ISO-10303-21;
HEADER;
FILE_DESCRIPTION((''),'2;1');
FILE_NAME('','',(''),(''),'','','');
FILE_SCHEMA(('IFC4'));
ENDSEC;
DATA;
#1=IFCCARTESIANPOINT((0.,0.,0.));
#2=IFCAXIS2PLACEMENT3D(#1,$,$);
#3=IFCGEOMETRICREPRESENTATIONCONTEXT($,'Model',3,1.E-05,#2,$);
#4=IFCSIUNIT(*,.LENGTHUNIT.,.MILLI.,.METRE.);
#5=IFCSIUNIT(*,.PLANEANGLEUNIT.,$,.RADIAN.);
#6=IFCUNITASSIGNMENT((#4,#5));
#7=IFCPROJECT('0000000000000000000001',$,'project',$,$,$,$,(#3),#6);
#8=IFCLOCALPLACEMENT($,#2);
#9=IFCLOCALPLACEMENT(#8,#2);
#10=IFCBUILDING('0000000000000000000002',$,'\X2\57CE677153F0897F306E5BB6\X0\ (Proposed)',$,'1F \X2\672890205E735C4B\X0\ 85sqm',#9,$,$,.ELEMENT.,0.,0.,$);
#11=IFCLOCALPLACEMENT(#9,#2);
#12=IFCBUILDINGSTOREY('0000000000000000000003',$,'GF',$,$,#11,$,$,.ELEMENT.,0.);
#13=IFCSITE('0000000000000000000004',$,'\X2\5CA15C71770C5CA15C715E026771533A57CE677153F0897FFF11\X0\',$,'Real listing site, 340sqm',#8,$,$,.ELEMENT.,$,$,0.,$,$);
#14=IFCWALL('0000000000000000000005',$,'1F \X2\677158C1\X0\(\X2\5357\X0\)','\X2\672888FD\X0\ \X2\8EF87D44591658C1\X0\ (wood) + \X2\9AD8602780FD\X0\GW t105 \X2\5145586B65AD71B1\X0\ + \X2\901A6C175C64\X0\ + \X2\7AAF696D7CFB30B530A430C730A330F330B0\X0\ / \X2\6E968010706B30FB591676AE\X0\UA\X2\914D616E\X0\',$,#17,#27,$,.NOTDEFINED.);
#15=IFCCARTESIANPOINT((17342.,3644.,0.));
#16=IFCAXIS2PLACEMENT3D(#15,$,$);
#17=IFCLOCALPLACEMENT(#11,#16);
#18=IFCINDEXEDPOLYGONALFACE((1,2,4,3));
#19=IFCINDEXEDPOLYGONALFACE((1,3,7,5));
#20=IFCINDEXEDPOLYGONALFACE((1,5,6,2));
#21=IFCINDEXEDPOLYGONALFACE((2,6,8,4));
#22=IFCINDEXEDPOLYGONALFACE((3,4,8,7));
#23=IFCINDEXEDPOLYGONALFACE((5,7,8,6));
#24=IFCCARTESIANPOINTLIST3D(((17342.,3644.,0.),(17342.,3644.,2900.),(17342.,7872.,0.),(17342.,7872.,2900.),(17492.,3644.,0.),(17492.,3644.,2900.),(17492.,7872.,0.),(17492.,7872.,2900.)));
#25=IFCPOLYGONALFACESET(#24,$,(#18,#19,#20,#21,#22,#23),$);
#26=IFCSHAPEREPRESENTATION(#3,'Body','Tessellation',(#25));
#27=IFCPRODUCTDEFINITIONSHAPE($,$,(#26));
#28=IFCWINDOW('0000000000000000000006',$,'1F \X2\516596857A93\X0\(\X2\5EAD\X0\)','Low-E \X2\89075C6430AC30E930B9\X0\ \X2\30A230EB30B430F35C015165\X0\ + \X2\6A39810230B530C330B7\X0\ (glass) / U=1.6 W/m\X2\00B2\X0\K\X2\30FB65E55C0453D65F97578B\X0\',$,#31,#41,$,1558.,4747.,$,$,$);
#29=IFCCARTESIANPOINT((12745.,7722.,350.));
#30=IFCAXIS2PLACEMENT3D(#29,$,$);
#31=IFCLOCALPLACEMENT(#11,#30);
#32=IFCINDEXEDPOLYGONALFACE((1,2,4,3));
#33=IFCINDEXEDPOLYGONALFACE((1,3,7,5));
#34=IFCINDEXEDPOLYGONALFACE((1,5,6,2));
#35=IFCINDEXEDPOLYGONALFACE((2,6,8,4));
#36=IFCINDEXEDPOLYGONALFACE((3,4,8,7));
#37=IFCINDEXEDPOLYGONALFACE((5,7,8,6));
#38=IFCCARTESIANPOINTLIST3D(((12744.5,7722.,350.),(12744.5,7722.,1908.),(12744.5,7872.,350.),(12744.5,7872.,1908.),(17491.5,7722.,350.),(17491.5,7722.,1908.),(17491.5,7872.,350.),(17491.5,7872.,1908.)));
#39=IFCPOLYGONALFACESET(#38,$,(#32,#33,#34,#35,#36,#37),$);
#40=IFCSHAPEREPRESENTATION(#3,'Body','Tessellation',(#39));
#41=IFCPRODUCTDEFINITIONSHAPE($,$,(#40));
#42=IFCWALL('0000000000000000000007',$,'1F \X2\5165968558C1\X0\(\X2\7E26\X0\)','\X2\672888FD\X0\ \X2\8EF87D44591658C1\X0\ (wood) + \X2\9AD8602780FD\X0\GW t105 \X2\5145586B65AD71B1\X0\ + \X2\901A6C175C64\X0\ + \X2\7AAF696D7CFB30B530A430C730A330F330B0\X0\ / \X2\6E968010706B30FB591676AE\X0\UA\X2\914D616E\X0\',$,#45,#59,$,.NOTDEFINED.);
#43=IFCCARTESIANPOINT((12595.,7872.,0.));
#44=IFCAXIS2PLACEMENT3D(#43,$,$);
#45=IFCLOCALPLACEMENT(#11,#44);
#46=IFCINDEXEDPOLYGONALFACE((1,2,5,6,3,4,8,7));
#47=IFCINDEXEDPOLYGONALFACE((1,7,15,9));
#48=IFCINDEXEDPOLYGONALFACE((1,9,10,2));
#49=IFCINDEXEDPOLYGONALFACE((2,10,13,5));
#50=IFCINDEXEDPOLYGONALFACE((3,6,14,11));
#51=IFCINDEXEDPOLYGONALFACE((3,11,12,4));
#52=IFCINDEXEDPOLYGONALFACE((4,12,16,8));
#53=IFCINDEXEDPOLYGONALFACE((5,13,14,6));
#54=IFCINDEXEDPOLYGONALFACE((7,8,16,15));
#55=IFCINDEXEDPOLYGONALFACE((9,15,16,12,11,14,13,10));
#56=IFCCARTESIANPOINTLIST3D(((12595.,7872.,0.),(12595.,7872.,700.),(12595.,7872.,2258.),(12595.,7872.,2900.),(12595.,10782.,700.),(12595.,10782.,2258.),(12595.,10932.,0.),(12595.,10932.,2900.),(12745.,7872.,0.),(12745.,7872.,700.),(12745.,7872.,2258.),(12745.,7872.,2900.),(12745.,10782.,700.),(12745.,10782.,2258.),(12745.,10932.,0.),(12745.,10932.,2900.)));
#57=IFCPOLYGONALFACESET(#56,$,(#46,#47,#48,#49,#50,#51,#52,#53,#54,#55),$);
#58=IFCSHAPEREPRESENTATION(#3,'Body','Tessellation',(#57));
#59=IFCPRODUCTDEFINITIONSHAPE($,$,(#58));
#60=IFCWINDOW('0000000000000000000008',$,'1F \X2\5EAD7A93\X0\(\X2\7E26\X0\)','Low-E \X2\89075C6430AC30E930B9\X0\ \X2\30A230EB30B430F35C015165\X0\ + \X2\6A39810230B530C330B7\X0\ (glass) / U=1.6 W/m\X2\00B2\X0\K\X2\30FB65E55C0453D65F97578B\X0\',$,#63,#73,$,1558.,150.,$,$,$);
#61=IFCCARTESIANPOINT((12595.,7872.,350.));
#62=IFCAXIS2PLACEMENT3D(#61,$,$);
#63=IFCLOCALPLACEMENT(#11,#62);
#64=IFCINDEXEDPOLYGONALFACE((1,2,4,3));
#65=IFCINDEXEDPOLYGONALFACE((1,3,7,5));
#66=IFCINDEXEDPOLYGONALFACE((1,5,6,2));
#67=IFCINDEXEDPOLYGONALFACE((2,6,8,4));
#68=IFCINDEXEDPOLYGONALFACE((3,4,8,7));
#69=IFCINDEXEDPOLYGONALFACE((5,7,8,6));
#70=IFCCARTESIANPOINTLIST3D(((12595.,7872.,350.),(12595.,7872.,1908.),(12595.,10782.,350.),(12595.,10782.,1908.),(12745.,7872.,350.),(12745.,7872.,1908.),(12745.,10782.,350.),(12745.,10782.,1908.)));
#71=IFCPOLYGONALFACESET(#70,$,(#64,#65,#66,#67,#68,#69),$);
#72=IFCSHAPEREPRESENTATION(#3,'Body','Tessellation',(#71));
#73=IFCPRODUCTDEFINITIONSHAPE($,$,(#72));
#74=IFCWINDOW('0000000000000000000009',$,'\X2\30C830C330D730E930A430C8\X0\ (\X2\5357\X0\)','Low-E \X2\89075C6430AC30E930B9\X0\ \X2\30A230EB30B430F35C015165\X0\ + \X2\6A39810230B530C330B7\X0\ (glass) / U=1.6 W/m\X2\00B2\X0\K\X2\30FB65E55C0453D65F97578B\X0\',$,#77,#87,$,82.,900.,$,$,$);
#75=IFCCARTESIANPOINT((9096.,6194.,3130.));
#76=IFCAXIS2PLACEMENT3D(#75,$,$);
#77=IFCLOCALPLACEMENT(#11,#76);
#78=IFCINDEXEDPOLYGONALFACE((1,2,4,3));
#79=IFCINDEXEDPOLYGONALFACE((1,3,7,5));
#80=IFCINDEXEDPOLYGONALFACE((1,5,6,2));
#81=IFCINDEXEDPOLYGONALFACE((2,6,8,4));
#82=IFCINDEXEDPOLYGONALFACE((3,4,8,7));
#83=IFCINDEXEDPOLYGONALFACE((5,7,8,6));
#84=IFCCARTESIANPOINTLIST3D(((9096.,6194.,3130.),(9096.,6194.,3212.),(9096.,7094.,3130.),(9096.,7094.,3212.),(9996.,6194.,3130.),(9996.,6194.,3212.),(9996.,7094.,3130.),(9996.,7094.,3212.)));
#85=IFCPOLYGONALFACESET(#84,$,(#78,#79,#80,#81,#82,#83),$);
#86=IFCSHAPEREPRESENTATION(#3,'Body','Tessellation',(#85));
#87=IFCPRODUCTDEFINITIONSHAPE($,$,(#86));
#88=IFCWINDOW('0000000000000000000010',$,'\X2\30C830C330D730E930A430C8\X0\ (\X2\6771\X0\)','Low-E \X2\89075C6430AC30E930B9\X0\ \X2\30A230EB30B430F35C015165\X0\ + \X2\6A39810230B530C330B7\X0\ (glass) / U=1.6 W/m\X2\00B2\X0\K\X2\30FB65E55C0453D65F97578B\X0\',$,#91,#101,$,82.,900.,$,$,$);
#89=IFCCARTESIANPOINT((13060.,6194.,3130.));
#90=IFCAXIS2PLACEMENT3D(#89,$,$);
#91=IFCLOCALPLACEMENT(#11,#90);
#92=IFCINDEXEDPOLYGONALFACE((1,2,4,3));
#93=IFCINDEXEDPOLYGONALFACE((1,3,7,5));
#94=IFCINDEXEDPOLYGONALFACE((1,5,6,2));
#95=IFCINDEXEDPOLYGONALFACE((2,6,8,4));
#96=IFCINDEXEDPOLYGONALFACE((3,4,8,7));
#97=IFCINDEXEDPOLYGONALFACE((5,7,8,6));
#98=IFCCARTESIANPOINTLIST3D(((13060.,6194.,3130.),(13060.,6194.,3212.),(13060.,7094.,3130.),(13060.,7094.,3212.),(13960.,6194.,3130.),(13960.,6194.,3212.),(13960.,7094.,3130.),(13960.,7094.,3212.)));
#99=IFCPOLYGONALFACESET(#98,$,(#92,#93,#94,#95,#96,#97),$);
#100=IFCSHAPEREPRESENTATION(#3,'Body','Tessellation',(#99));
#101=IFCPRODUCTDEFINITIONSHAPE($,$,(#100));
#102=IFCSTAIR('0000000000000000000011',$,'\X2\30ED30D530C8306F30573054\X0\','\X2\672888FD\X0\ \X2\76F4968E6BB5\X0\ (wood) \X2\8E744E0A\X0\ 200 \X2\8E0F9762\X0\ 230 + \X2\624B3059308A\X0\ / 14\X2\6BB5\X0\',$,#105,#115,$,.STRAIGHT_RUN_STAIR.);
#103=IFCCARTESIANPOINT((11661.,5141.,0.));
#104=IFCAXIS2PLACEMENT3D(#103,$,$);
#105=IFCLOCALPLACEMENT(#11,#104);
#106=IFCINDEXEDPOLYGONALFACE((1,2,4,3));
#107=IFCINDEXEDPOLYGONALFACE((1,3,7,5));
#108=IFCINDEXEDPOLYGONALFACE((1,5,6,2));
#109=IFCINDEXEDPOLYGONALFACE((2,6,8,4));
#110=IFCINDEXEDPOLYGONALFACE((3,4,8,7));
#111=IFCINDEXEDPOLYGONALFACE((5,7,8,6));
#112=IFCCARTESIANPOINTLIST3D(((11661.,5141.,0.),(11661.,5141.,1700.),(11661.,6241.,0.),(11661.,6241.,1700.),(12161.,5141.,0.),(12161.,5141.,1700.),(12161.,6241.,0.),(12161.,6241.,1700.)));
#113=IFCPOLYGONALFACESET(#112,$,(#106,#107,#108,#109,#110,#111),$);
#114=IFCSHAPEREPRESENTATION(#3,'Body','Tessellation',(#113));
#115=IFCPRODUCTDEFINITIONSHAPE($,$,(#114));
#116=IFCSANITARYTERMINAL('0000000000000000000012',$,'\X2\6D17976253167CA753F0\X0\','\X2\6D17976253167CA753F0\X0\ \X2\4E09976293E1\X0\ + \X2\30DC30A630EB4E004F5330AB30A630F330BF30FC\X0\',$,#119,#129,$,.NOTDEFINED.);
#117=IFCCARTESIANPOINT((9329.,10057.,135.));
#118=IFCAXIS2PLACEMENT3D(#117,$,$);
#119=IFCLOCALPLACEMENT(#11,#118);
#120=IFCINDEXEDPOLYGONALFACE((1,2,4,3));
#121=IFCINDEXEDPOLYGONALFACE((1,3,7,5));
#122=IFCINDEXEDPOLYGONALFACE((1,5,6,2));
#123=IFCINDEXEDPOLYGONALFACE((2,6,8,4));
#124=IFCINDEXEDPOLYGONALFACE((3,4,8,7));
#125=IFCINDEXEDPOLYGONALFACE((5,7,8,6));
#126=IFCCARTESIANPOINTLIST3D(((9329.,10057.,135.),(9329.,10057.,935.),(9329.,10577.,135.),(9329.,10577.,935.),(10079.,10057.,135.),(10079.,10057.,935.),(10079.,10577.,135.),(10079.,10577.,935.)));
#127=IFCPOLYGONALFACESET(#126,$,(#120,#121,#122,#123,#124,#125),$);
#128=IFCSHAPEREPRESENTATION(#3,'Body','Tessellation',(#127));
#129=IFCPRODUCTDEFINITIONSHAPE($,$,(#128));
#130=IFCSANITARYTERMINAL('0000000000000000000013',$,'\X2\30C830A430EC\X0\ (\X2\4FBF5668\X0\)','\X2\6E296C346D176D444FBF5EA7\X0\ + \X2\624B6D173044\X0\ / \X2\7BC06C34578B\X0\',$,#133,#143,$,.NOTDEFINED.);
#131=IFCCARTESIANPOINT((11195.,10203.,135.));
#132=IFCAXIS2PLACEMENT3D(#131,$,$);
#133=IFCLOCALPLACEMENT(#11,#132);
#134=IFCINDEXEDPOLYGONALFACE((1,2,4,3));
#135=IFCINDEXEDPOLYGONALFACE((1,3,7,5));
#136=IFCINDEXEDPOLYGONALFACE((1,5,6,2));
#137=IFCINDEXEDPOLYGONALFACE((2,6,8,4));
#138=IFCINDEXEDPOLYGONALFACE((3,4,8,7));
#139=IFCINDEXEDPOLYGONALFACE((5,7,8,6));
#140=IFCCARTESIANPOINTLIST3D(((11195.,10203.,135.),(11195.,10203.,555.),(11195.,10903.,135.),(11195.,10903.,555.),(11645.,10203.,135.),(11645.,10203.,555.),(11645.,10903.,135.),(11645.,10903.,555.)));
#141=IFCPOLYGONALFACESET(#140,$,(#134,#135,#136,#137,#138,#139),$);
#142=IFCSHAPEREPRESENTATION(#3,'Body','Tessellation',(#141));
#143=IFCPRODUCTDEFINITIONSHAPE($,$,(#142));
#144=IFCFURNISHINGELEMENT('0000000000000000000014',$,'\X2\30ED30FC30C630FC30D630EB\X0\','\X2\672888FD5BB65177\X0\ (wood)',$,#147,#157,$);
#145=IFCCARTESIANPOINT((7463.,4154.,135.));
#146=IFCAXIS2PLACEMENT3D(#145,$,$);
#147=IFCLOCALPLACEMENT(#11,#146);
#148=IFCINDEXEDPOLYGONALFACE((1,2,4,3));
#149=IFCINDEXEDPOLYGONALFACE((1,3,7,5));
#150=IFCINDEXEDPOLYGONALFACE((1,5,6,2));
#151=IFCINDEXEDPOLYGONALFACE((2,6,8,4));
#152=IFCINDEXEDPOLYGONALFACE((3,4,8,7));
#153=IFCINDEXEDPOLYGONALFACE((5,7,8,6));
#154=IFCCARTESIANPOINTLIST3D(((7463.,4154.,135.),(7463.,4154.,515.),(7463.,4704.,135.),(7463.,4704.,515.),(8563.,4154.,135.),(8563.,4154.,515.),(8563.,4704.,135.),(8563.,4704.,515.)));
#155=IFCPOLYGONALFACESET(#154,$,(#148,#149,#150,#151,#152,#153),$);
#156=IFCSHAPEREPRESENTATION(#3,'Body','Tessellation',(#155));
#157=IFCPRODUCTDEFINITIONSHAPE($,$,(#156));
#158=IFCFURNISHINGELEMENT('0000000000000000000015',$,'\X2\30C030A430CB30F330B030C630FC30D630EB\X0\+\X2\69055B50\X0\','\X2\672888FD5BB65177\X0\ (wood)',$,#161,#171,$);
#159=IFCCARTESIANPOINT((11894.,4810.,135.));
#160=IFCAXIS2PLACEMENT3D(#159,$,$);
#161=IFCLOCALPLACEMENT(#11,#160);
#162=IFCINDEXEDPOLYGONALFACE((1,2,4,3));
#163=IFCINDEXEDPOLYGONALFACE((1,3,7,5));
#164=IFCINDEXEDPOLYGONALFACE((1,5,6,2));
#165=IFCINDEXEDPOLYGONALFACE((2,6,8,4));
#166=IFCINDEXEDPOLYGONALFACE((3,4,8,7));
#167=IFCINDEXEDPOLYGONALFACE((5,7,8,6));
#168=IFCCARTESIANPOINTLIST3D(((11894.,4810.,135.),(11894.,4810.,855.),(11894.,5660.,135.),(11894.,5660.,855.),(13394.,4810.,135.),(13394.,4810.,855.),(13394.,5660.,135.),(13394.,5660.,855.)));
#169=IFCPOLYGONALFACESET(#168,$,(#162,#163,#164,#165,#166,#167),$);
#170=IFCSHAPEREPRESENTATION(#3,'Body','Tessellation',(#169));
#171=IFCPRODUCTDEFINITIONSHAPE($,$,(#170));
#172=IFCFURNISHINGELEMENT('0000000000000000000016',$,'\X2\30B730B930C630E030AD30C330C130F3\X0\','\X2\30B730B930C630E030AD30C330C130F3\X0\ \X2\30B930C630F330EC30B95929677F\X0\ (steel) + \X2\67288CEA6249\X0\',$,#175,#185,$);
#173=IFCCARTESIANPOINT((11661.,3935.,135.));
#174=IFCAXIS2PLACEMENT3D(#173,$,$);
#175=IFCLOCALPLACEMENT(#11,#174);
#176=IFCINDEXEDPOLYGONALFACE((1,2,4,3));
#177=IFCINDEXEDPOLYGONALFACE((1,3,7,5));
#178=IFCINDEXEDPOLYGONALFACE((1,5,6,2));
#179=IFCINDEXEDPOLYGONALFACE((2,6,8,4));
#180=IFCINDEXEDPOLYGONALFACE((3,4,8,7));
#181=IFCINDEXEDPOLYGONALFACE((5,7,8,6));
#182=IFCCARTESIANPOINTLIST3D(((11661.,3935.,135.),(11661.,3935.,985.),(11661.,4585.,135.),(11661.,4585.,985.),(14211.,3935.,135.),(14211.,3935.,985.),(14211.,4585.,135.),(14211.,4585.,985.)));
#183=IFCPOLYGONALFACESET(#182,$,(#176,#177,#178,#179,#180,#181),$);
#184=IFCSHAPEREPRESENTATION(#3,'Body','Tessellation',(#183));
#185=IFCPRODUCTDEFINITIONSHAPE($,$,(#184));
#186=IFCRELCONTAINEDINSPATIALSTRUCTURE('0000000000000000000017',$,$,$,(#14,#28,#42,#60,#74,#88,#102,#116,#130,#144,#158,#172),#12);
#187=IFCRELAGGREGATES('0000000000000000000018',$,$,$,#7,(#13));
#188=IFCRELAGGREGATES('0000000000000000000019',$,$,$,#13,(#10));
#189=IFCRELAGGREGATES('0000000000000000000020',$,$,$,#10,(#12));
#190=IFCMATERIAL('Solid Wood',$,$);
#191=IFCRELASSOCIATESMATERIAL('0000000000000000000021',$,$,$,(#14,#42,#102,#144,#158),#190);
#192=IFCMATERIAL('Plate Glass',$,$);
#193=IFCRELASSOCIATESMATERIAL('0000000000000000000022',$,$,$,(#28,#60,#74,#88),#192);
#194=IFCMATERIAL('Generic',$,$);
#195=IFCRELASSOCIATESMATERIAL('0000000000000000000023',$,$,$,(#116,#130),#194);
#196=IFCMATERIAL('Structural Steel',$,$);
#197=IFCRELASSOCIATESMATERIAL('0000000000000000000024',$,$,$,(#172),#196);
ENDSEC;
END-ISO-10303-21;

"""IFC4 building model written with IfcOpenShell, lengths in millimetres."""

from ifc_helpers import new_model, si_unit, frame, frame_2d, origin, place, context, project, spatial, rectangle, extrude, material, element, fill, save


model = new_model("IFC4")

# Units and contexts
model_context = context("Model", 3, precision=1e-05, world=origin())
ifc_project = project(units=[si_unit("LENGTHUNIT", "METRE", prefix="MILLI"), si_unit("PLANEANGLEUNIT", "RADIAN")], contexts=[model_context])

# Site, building, storey
site_placement = place(None, origin())
site = spatial("IfcSite", under=ifc_project, at=site_placement, Name="岡山県岡山市東区城東台西１", ObjectType="Real listing site, 340sqm", CompositionType="ELEMENT", RefElevation=0.0)
building_placement = place(site_placement, origin())
building = spatial("IfcBuilding", under=site, at=building_placement, Name="城東台西の家 (Proposed)", ObjectType="1F 木造平屋 85sqm", CompositionType="ELEMENT", ElevationOfRefHeight=0.0, ElevationOfTerrain=0.0)
storey_placement = place(building_placement, origin())
storey = spatial("IfcBuildingStorey", under=building, at=storey_placement, Name="GF", CompositionType="ELEMENT", Elevation=0.0)

# Shared definitions
ifc_material_1 = material(Name="Solid Wood")

# Wall, opening, window
wall_1_placement = place(storey_placement, frame((17342.0, 3644.0, 0.0)))
wall_1 = element("IfcWall", 1, at=wall_1_placement, inside=storey, material=ifc_material_1, Name="1F 東壁(南)", Description="木製 軸組外壁 (wood) + 高性能GW t105 充填断熱 + 通気層 + 窯業系サイディング / 準耐火・外皮UA配慮", PredefinedType="NOTDEFINED", context=model_context, shape_type="SweptSolid", body=[
    extrude(rectangle(XDim=150.0, YDim=4228.0, at=frame_2d((75.0, 2114.0))), frame((17342.0, 3644.0, 0.0)), (0.0, 0.0, 1.0), 2900.0),
])
opening_1_placement = place(storey_placement, frame((12745.0, 7722.0, 350.0)))
opening_1 = element("IfcOpeningElement", 2, at=opening_1_placement, cuts=wall_1, PredefinedType="NOTDEFINED", context=model_context, shape_type="SweptSolid", body=[
    extrude(rectangle(XDim=4747.0, YDim=150.0, at=frame_2d((2373.0, 75.0))), frame((12745.0, 7722.0, 350.0)), (0.0, 0.0, 1.0), 1558.0),
])
ifc_material_2 = material(Name="Plate Glass")
window_1_placement = place(storey_placement, frame((12745.0, 7722.0, 350.0)))
window_1 = element("IfcWindow", 3, at=window_1_placement, inside=storey, material=ifc_material_2, Name="1F 入隅窓(庭)", Description="Low-E 複層ガラス アルゴン封入 + 樹脂サッシ (glass) / U=1.6 W/m²K・日射取得型", OverallHeight=1558.0, OverallWidth=4747.0, context=model_context, shape_type="SweptSolid", body=[
    extrude(rectangle(XDim=4747.0, YDim=150.0, at=frame_2d((2373.0, 75.0))), frame((12745.0, 7722.0, 350.0)), (0.0, 0.0, 1.0), 1558.0),
])
fill(opening_1, window_1)

# Wall, opening, window
wall_2_placement = place(storey_placement, frame((12595.0, 7872.0, 0.0)))
wall_2 = element("IfcWall", 4, at=wall_2_placement, inside=storey, material=ifc_material_1, Name="1F 入隅壁(縦)", Description="木製 軸組外壁 (wood) + 高性能GW t105 充填断熱 + 通気層 + 窯業系サイディング / 準耐火・外皮UA配慮", PredefinedType="NOTDEFINED", context=model_context, shape_type="SweptSolid", body=[
    extrude(rectangle(XDim=150.0, YDim=3060.0, at=frame_2d((75.0, 1530.0))), frame((12595.0, 7872.0, 0.0)), (0.0, 0.0, 1.0), 2900.0),
])
opening_2_placement = place(storey_placement, frame((12595.0, 7872.0, 350.0)))
opening_2 = element("IfcOpeningElement", 5, at=opening_2_placement, cuts=wall_2, PredefinedType="NOTDEFINED", context=model_context, shape_type="SweptSolid", body=[
    extrude(rectangle(XDim=150.0, YDim=2910.0, at=frame_2d((75.0, 1455.0))), frame((12595.0, 7872.0, 350.0)), (0.0, 0.0, 1.0), 1558.0),
])
window_2_placement = place(storey_placement, frame((12595.0, 7872.0, 350.0)))
window_2 = element("IfcWindow", 6, at=window_2_placement, inside=storey, material=ifc_material_2, Name="1F 庭窓(縦)", Description="Low-E 複層ガラス アルゴン封入 + 樹脂サッシ (glass) / U=1.6 W/m²K・日射取得型", OverallHeight=1558.0, OverallWidth=150.0, context=model_context, shape_type="SweptSolid", body=[
    extrude(rectangle(XDim=150.0, YDim=2910.0, at=frame_2d((75.0, 1455.0))), frame((12595.0, 7872.0, 350.0)), (0.0, 0.0, 1.0), 1558.0),
])
fill(opening_2, window_2)

# Windows
window_3_placement = place(storey_placement, frame((9096.0, 6194.0, 3130.0)))
element("IfcWindow", 7, at=window_3_placement, inside=storey, material=ifc_material_2, Name="トップライト (南)", Description="Low-E 複層ガラス アルゴン封入 + 樹脂サッシ (glass) / U=1.6 W/m²K・日射取得型", OverallHeight=82.0, OverallWidth=900.0, context=model_context, shape_type="SweptSolid", body=[
    extrude(rectangle(XDim=900.0, YDim=900.0, at=frame_2d((450.0, 450.0))), frame((9096.0, 6194.0, 3130.0)), (0.0, 0.0, 1.0), 82.0),
])
window_4_placement = place(storey_placement, frame((13060.0, 6194.0, 3130.0)))
element("IfcWindow", 8, at=window_4_placement, inside=storey, material=ifc_material_2, Name="トップライト (東)", Description="Low-E 複層ガラス アルゴン封入 + 樹脂サッシ (glass) / U=1.6 W/m²K・日射取得型", OverallHeight=82.0, OverallWidth=900.0, context=model_context, shape_type="SweptSolid", body=[
    extrude(rectangle(XDim=900.0, YDim=900.0, at=frame_2d((450.0, 450.0))), frame((13060.0, 6194.0, 3130.0)), (0.0, 0.0, 1.0), 82.0),
])

# Stair
stair_placement = place(storey_placement, frame((11661.0, 5141.0, 0.0)))
element("IfcStair", 9, at=stair_placement, inside=storey, material=ifc_material_1, Name="ロフトはしご", Description="木製 直階段 (wood) 蹴上 200 踏面 230 + 手すり / 14段", PredefinedType="STRAIGHT_RUN_STAIR", context=model_context, shape_type="SweptSolid", body=[
    extrude(rectangle(XDim=500.0, YDim=1100.0, at=frame_2d((250.0, 550.0))), frame((11661.0, 5141.0, 0.0)), (0.0, 0.0, 1.0), 1700.0),
])

# Sanitary terminals
ifc_material_3 = material(Name="Generic")
sanitary_terminal_1_placement = place(storey_placement, frame((9329.0, 10057.0, 135.0)))
element("IfcSanitaryTerminal", 10, at=sanitary_terminal_1_placement, inside=storey, material=ifc_material_3, Name="洗面化粧台", Description="洗面化粧台 三面鏡 + ボウル一体カウンター", PredefinedType="NOTDEFINED", context=model_context, shape_type="SweptSolid", body=[
    extrude(rectangle(XDim=750.0, YDim=520.0, at=frame_2d((375.0, 260.0))), frame((9329.0, 10057.0, 135.0)), (0.0, 0.0, 1.0), 800.0),
])
sanitary_terminal_2_placement = place(storey_placement, frame((11195.0, 10203.0, 135.0)))
element("IfcSanitaryTerminal", 11, at=sanitary_terminal_2_placement, inside=storey, material=ifc_material_3, Name="トイレ (便器)", Description="温水洗浄便座 + 手洗い / 節水型", PredefinedType="NOTDEFINED", context=model_context, shape_type="SweptSolid", body=[
    extrude(rectangle(XDim=450.0, YDim=700.0, at=frame_2d((225.0, 350.0))), frame((11195.0, 10203.0, 135.0)), (0.0, 0.0, 1.0), 420.0),
])

# Furnishing elements
furnishing_1_placement = place(storey_placement, frame((7463.0, 4154.0, 135.0)))
element("IfcFurnishingElement", 12, at=furnishing_1_placement, inside=storey, material=ifc_material_1, Name="ローテーブル", Description="木製家具 (wood)", context=model_context, shape_type="SweptSolid", body=[
    extrude(rectangle(XDim=1100.0, YDim=550.0, at=frame_2d((550.0, 275.0))), frame((7463.0, 4154.0, 135.0)), (0.0, 0.0, 1.0), 380.0),
])
furnishing_2_placement = place(storey_placement, frame((11894.0, 4810.0, 135.0)))
element("IfcFurnishingElement", 13, at=furnishing_2_placement, inside=storey, material=ifc_material_1, Name="ダイニングテーブル+椅子", Description="木製家具 (wood)", context=model_context, shape_type="SweptSolid", body=[
    extrude(rectangle(XDim=1500.0, YDim=850.0, at=frame_2d((750.0, 425.0))), frame((11894.0, 4810.0, 135.0)), (0.0, 0.0, 1.0), 720.0),
])
ifc_material_4 = material(Name="Structural Steel")
furnishing_3_placement = place(storey_placement, frame((11661.0, 3935.0, 135.0)))
element("IfcFurnishingElement", 14, at=furnishing_3_placement, inside=storey, material=ifc_material_4, Name="システムキッチン", Description="システムキッチン ステンレス天板 (steel) + 木質扉", context=model_context, shape_type="SweptSolid", body=[
    extrude(rectangle(XDim=2550.0, YDim=650.0, at=frame_2d((1275.0, 325.0))), frame((11661.0, 3935.0, 135.0)), (0.0, 0.0, 1.0), 850.0),
])

save(model, "model.ifc")
